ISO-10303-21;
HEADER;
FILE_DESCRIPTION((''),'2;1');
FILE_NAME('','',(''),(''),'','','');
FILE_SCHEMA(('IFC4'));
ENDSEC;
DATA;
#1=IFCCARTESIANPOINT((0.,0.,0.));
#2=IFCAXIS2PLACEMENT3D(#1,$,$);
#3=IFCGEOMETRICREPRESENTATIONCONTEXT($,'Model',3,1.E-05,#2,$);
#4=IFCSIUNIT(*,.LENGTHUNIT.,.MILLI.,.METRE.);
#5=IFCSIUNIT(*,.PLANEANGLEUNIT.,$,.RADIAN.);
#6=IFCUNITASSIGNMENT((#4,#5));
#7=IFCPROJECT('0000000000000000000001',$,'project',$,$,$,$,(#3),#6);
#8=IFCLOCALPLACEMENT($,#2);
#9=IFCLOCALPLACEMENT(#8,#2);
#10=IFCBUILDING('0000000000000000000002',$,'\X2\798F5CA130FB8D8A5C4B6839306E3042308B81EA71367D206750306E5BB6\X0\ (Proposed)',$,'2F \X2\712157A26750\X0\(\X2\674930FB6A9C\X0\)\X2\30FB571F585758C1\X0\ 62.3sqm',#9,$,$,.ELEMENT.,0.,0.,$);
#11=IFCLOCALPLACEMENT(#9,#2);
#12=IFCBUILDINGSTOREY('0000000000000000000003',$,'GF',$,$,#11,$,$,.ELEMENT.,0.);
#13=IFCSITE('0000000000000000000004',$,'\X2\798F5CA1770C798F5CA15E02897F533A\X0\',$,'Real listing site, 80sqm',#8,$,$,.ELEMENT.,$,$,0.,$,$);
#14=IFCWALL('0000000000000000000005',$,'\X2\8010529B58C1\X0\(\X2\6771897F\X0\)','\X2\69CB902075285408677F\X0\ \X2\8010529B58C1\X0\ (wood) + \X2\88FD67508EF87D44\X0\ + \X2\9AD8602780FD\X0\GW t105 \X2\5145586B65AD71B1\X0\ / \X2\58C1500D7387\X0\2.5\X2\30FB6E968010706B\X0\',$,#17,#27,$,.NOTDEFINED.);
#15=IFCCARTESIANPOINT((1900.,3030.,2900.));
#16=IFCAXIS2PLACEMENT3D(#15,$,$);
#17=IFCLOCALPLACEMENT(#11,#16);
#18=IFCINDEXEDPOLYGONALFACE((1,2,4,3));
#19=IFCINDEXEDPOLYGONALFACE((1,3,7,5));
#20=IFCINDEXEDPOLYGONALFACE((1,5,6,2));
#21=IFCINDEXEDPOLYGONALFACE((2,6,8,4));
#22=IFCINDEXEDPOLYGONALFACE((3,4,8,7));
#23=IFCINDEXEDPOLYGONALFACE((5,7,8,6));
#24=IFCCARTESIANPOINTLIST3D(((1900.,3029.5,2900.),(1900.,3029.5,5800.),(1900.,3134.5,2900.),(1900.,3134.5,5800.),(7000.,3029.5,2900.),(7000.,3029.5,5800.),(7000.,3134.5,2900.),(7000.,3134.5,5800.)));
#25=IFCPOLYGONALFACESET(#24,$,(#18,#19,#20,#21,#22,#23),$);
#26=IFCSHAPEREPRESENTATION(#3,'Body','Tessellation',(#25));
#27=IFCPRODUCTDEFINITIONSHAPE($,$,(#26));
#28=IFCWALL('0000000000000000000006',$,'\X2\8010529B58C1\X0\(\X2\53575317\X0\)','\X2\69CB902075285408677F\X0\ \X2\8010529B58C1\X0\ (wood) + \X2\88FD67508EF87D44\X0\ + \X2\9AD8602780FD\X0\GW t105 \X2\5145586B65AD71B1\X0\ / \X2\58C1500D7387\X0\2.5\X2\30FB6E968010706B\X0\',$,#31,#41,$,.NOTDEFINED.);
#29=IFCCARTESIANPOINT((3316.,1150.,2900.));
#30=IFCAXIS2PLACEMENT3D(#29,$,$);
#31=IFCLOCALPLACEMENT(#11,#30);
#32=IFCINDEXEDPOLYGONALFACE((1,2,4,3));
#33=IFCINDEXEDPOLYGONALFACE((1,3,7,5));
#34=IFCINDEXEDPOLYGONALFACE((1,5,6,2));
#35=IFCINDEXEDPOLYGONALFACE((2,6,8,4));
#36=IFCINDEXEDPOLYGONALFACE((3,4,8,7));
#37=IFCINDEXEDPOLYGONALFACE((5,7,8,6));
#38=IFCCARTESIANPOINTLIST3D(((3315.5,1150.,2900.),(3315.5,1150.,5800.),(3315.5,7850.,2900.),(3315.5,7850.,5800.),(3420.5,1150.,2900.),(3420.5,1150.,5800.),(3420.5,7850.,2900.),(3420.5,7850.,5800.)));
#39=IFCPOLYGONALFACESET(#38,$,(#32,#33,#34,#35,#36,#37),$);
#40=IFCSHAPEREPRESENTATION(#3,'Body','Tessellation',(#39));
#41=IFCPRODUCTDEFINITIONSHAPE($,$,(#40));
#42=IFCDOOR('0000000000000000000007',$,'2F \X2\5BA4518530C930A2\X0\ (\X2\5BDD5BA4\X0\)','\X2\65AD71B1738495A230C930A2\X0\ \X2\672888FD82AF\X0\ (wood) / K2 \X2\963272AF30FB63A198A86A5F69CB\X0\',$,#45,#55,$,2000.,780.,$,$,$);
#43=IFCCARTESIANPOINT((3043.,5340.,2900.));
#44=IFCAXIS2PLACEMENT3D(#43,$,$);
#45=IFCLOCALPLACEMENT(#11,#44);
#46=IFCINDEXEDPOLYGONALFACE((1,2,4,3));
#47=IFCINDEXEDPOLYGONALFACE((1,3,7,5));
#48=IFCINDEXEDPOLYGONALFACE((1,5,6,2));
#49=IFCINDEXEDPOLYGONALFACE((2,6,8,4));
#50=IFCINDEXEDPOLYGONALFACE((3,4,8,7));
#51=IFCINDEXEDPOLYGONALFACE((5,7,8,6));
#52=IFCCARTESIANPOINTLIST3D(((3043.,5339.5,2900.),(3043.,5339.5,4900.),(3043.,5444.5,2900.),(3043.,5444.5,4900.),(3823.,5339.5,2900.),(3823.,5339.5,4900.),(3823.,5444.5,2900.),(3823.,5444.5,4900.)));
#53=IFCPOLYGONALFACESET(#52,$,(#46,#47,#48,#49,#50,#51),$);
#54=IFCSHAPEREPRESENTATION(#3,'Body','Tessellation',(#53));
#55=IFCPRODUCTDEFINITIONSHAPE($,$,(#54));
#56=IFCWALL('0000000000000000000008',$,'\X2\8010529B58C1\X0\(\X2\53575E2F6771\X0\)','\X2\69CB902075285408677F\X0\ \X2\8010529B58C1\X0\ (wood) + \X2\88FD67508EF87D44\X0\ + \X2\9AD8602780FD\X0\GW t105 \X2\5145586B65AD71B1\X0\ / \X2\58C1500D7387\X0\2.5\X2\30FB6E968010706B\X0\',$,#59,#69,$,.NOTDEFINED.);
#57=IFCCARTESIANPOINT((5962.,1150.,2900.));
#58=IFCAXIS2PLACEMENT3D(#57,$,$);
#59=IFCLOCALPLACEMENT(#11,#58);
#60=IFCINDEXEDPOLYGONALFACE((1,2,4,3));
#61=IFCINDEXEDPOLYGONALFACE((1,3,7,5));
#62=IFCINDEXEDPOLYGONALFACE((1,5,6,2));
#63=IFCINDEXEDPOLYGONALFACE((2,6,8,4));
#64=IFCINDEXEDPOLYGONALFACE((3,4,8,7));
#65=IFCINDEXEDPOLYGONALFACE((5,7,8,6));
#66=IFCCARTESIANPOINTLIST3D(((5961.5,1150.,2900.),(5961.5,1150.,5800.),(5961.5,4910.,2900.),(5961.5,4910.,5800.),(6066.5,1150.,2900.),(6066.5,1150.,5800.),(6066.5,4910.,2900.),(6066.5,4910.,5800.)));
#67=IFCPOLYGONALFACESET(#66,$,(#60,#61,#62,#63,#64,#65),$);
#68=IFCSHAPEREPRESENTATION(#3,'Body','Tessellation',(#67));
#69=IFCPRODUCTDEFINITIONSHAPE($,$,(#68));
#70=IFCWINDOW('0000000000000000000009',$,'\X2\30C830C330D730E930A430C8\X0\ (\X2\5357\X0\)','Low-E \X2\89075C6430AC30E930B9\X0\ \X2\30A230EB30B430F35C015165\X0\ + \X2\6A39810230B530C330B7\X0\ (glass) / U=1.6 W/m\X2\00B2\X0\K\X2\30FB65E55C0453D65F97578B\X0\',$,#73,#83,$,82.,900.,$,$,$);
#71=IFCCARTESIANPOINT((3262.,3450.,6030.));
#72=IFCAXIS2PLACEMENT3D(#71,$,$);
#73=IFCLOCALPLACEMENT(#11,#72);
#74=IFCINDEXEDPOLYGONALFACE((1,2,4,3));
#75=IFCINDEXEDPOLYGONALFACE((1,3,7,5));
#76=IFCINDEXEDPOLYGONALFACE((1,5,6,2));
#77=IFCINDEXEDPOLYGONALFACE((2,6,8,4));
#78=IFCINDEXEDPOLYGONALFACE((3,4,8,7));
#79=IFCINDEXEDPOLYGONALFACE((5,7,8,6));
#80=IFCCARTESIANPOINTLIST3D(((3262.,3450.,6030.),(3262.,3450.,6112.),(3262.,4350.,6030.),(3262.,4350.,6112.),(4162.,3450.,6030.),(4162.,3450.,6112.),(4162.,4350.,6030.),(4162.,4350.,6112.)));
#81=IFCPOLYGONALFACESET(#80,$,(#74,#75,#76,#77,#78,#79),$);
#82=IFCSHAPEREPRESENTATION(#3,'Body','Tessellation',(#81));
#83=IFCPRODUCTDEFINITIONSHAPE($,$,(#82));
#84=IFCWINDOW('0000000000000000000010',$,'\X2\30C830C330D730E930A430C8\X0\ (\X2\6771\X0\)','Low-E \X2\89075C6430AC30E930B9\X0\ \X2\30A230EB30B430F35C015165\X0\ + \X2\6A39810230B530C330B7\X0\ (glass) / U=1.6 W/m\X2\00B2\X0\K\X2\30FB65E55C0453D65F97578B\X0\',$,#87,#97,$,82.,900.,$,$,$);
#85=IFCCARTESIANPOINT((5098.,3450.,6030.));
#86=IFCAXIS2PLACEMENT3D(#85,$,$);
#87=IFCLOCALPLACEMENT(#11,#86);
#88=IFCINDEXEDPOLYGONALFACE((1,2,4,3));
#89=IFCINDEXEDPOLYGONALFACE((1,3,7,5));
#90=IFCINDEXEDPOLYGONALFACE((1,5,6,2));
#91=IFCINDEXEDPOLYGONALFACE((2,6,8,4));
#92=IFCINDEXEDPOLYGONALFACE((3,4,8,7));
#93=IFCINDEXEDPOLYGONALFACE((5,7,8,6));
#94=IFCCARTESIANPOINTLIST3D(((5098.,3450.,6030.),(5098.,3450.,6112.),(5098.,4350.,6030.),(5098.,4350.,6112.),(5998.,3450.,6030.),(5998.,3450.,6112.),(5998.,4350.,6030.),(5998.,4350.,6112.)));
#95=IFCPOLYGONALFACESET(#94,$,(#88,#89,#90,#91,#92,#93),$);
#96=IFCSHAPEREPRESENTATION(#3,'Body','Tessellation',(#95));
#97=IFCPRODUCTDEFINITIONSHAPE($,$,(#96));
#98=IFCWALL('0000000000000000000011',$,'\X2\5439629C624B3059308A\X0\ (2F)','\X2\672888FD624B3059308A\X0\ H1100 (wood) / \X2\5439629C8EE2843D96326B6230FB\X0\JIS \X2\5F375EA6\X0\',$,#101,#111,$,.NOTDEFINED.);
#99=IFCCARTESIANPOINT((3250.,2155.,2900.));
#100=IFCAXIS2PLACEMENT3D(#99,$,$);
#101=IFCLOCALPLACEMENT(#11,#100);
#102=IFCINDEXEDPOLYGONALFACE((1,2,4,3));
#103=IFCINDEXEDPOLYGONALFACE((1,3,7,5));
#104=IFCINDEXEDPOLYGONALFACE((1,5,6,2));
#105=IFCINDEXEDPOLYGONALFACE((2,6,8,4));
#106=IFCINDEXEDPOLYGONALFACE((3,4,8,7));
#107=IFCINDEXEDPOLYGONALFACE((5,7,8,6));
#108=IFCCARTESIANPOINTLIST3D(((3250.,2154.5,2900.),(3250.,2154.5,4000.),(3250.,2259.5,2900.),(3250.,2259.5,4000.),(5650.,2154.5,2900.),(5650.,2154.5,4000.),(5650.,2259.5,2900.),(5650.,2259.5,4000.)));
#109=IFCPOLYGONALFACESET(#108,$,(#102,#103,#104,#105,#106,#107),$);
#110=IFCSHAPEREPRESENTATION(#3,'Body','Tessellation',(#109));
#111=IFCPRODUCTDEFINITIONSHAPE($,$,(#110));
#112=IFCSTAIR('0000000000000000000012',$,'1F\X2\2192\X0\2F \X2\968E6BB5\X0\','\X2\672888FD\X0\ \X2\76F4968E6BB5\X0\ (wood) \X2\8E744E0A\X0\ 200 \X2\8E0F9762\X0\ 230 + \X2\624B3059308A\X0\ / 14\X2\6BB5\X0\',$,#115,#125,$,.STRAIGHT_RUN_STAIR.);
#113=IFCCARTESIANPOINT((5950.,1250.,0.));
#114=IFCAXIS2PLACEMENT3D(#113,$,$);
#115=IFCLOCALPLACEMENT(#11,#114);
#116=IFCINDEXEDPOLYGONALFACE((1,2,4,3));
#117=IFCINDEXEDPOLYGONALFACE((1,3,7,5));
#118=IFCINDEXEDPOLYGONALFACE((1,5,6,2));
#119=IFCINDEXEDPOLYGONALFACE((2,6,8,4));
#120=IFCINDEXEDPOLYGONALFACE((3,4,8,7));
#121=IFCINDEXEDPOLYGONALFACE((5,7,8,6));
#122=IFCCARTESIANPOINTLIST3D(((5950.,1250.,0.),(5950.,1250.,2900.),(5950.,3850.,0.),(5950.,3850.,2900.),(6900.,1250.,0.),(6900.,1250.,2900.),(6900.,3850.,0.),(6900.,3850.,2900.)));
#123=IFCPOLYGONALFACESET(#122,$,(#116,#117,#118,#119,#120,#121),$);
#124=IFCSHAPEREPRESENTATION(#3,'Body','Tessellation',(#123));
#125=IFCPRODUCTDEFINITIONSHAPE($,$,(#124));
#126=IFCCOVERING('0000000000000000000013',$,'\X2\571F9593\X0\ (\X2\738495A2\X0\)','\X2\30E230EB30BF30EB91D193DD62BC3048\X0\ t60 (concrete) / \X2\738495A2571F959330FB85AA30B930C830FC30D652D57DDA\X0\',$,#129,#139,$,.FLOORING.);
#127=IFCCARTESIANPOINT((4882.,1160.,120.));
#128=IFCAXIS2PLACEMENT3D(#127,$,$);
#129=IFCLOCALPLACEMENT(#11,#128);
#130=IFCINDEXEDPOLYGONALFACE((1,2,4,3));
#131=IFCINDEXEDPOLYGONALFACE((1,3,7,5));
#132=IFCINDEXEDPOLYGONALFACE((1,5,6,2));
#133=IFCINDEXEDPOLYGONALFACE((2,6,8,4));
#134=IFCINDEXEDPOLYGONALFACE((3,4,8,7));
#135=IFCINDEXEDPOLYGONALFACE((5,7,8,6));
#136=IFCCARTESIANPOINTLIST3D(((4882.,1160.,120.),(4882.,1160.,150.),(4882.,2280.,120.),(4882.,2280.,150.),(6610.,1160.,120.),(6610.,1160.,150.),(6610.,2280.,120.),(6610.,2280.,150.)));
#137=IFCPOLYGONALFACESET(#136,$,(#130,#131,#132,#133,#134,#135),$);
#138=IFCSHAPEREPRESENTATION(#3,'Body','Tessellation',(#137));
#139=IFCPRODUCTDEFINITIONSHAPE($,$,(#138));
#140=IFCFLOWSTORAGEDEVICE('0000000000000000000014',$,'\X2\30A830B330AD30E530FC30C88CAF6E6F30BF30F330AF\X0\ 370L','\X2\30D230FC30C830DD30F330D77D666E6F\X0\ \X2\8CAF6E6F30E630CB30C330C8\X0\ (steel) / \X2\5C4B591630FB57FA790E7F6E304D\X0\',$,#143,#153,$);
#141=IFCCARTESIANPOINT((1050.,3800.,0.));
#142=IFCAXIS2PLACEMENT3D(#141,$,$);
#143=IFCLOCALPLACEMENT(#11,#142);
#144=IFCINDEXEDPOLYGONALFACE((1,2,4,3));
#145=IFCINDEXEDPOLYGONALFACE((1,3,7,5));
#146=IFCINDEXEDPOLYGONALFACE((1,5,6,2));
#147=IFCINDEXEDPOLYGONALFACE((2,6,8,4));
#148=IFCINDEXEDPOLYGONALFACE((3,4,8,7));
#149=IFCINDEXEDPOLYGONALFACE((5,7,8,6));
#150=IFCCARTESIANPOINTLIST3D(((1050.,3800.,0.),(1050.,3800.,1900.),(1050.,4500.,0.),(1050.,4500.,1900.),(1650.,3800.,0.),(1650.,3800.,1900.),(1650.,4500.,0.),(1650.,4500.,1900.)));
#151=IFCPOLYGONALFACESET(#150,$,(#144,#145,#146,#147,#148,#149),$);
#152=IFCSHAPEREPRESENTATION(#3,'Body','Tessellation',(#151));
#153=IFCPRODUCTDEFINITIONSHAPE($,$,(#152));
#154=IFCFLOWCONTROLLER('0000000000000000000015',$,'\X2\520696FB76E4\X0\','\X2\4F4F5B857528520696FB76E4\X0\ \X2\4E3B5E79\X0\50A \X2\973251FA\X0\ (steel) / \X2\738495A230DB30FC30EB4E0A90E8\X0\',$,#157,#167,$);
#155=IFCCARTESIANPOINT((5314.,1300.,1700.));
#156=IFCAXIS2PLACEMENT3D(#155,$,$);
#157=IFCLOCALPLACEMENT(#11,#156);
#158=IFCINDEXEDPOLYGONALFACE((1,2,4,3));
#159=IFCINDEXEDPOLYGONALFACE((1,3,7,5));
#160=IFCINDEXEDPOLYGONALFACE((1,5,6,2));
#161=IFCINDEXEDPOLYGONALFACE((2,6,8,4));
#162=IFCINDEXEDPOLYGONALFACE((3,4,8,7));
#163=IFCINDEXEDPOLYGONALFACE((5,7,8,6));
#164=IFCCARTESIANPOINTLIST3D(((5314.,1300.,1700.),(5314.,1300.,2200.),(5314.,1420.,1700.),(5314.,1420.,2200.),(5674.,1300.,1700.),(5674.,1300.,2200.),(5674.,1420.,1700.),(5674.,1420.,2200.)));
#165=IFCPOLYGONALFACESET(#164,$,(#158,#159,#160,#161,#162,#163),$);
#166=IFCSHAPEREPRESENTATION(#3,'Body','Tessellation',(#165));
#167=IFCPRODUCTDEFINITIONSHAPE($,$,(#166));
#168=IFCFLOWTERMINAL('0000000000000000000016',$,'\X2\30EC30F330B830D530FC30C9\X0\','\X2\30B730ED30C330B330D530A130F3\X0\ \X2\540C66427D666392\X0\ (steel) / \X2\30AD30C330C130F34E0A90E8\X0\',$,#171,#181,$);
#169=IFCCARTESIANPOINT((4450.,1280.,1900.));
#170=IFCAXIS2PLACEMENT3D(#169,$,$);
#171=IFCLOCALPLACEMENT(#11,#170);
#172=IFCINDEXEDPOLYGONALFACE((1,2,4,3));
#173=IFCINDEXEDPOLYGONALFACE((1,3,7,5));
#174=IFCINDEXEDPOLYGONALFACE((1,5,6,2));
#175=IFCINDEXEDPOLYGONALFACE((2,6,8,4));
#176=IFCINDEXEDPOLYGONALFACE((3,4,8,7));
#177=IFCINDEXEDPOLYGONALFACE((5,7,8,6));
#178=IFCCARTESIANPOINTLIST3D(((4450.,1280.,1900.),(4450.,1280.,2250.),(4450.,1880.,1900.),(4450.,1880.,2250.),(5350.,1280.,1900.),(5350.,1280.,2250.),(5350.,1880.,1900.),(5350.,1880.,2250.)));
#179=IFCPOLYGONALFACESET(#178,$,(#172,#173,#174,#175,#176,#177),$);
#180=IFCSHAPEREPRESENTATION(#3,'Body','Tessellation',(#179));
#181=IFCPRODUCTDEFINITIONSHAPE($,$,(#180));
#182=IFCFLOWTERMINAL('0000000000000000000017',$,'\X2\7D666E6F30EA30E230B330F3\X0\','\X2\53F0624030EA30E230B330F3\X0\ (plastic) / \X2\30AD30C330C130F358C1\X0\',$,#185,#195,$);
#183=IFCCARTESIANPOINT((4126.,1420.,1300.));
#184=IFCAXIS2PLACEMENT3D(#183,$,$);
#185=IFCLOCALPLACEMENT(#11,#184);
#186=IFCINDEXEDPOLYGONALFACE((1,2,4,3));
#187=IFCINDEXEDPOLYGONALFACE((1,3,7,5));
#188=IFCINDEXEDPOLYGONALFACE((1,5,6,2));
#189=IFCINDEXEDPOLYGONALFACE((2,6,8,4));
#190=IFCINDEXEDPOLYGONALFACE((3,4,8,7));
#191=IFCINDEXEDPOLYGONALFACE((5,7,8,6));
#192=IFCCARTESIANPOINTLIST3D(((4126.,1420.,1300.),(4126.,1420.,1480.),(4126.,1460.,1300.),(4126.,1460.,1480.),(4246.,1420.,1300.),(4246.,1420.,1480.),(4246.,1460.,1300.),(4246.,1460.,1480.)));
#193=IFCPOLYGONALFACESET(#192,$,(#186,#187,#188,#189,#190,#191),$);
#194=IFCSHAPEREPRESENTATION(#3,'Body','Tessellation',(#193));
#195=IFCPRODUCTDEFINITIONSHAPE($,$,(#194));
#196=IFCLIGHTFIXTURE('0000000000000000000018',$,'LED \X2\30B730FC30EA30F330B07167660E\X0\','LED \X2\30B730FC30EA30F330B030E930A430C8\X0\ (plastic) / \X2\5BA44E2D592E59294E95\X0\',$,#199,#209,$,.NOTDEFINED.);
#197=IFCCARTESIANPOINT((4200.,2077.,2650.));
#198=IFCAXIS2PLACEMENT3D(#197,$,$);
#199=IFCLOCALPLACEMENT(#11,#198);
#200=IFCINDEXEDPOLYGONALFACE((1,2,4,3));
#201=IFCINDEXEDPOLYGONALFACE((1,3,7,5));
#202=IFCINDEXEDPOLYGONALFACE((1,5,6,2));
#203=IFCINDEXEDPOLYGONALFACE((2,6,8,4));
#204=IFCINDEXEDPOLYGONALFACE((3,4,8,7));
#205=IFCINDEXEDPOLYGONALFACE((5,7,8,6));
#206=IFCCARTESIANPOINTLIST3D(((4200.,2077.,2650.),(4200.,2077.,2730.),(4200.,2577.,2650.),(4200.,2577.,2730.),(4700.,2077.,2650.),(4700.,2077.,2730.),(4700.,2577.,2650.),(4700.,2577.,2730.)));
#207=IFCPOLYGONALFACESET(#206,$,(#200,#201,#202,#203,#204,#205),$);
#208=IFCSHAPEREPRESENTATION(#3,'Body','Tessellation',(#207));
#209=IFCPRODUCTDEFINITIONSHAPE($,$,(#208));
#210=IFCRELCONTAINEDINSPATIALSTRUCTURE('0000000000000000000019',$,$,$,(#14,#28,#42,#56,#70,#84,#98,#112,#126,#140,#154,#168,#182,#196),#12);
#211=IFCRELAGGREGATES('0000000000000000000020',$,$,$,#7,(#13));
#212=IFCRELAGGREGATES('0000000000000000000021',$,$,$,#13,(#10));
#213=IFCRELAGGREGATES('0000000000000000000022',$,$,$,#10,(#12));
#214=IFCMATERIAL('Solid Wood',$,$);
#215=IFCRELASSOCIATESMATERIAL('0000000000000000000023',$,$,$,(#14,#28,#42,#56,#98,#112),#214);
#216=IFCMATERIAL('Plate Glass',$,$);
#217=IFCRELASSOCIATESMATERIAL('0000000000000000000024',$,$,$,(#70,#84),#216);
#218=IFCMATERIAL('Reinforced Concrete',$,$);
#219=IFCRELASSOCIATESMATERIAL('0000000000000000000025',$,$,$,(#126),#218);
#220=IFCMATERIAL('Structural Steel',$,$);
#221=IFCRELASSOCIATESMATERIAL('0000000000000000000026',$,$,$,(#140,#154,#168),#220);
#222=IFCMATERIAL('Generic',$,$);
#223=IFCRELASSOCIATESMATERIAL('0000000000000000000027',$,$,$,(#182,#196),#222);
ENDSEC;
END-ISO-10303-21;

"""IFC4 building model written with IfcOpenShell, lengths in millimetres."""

from ifc_helpers import new_model, si_unit, frame, frame_2d, origin, place, context, project, spatial, rectangle, extrude, material, element, fill, save


model = new_model("IFC4")

# Units and contexts
model_context = context("Model", 3, precision=1e-05, world=origin())
ifc_project = project(units=[si_unit("LENGTHUNIT", "METRE", prefix="MILLI"), si_unit("PLANEANGLEUNIT", "RADIAN")], contexts=[model_context])

# Site, building, storey
site_placement = place(None, origin())
site = spatial("IfcSite", under=ifc_project, at=site_placement, Name="福岡県福岡市西区", ObjectType="Real listing site, 80sqm", CompositionType="ELEMENT", RefElevation=0.0)
building_placement = place(site_placement, origin())
building = spatial("IfcBuilding", under=site, at=building_placement, Name="福岡・越屋根のある自然素材の家 (Proposed)", ObjectType="2F 無垢材(杉・檜)・土塗壁 62.3sqm", CompositionType="ELEMENT", ElevationOfRefHeight=0.0, ElevationOfTerrain=0.0)
storey_placement = place(building_placement, origin())
storey = spatial("IfcBuildingStorey", under=building, at=storey_placement, Name="GF", CompositionType="ELEMENT", Elevation=0.0)

# Shared definitions
ifc_material_1 = material(Name="Solid Wood")

# Wall
wall_1_placement = place(storey_placement, frame((1900.0, 3030.0, 2900.0)))
element("IfcWall", 1, at=wall_1_placement, inside=storey, material=ifc_material_1, Name="耐力壁(東西)", Description="構造用合板 耐力壁 (wood) + 製材軸組 + 高性能GW t105 充填断熱 / 壁倍率2.5・準耐火", PredefinedType="NOTDEFINED", context=model_context, shape_type="SweptSolid", body=[
    extrude(rectangle(XDim=5100.0, YDim=105.0, at=frame_2d((2550.0, 52.0))), frame((1900.0, 3030.0, 2900.0)), (0.0, 0.0, 1.0), 2900.0),
])

# Wall, opening, door
wall_2_placement = place(storey_placement, frame((3316.0, 1150.0, 2900.0)))
wall_2 = element("IfcWall", 2, at=wall_2_placement, inside=storey, material=ifc_material_1, Name="耐力壁(南北)", Description="構造用合板 耐力壁 (wood) + 製材軸組 + 高性能GW t105 充填断熱 / 壁倍率2.5・準耐火", PredefinedType="NOTDEFINED", context=model_context, shape_type="SweptSolid", body=[
    extrude(rectangle(XDim=105.0, YDim=6700.0, at=frame_2d((52.0, 3350.0))), frame((3316.0, 1150.0, 2900.0)), (0.0, 0.0, 1.0), 2900.0),
])
opening_placement = place(storey_placement, frame((3043.0, 5340.0, 2900.0)))
opening = element("IfcOpeningElement", 3, at=opening_placement, cuts=wall_2, PredefinedType="NOTDEFINED", context=model_context, shape_type="SweptSolid", body=[
    extrude(rectangle(XDim=780.0, YDim=105.0, at=frame_2d((390.0, 52.0))), frame((3043.0, 5340.0, 2900.0)), (0.0, 0.0, 1.0), 2000.0),
])
door_placement = place(storey_placement, frame((3043.0, 5340.0, 2900.0)))
door = element("IfcDoor", 4, at=door_placement, inside=storey, material=ifc_material_1, Name="2F 室内ドア (寝室)", Description="断熱玄関ドア 木製芯 (wood) / K2 防犯・採風機構", OverallHeight=2000.0, OverallWidth=780.0, context=model_context, shape_type="SweptSolid", body=[
    extrude(rectangle(XDim=780.0, YDim=105.0, at=frame_2d((390.0, 52.0))), frame((3043.0, 5340.0, 2900.0)), (0.0, 0.0, 1.0), 2000.0),
])
fill(opening, door)

# Wall
wall_3_placement = place(storey_placement, frame((5962.0, 1150.0, 2900.0)))
element("IfcWall", 5, at=wall_3_placement, inside=storey, material=ifc_material_1, Name="耐力壁(南帯東)", Description="構造用合板 耐力壁 (wood) + 製材軸組 + 高性能GW t105 充填断熱 / 壁倍率2.5・準耐火", PredefinedType="NOTDEFINED", context=model_context, shape_type="SweptSolid", body=[
    extrude(rectangle(XDim=105.0, YDim=3760.0, at=frame_2d((52.0, 1880.0))), frame((5962.0, 1150.0, 2900.0)), (0.0, 0.0, 1.0), 2900.0),
])

# Windows
ifc_material_2 = material(Name="Plate Glass")
window_1_placement = place(storey_placement, frame((3262.0, 3450.0, 6030.0)))
element("IfcWindow", 6, at=window_1_placement, inside=storey, material=ifc_material_2, Name="トップライト (南)", Description="Low-E 複層ガラス アルゴン封入 + 樹脂サッシ (glass) / U=1.6 W/m²K・日射取得型", OverallHeight=82.0, OverallWidth=900.0, context=model_context, shape_type="SweptSolid", body=[
    extrude(rectangle(XDim=900.0, YDim=900.0, at=frame_2d((450.0, 450.0))), frame((3262.0, 3450.0, 6030.0)), (0.0, 0.0, 1.0), 82.0),
])
window_2_placement = place(storey_placement, frame((5098.0, 3450.0, 6030.0)))
element("IfcWindow", 7, at=window_2_placement, inside=storey, material=ifc_material_2, Name="トップライト (東)", Description="Low-E 複層ガラス アルゴン封入 + 樹脂サッシ (glass) / U=1.6 W/m²K・日射取得型", OverallHeight=82.0, OverallWidth=900.0, context=model_context, shape_type="SweptSolid", body=[
    extrude(rectangle(XDim=900.0, YDim=900.0, at=frame_2d((450.0, 450.0))), frame((5098.0, 3450.0, 6030.0)), (0.0, 0.0, 1.0), 82.0),
])

# Wall
wall_4_placement = place(storey_placement, frame((3250.0, 2155.0, 2900.0)))
element("IfcWall", 8, at=wall_4_placement, inside=storey, material=ifc_material_1, Name="吹抜手すり (2F)", Description="木製手すり H1100 (wood) / 吹抜転落防止・JIS 強度", PredefinedType="NOTDEFINED", context=model_context, shape_type="SweptSolid", body=[
    extrude(rectangle(XDim=2400.0, YDim=105.0, at=frame_2d((1200.0, 52.0))), frame((3250.0, 2155.0, 2900.0)), (0.0, 0.0, 1.0), 1100.0),
])

# Stair
stair_placement = place(storey_placement, frame((5950.0, 1250.0, 0.0)))
element("IfcStair", 9, at=stair_placement, inside=storey, material=ifc_material_1, Name="1F→2F 階段", Description="木製 直階段 (wood) 蹴上 200 踏面 230 + 手すり / 14段", PredefinedType="STRAIGHT_RUN_STAIR", context=model_context, shape_type="SweptSolid", body=[
    extrude(rectangle(XDim=950.0, YDim=2600.0, at=frame_2d((475.0, 1300.0))), frame((5950.0, 1250.0, 0.0)), (0.0, 0.0, 1.0), 2900.0),
])

# Covering
ifc_material_3 = material(Name="Reinforced Concrete")
covering_placement = place(storey_placement, frame((4882.0, 1160.0, 120.0)))
element("IfcCovering", 10, at=covering_placement, inside=storey, material=ifc_material_3, Name="土間 (玄関)", Description="モルタル金鏝押え t60 (concrete) / 玄関土間・薪ストーブ動線", PredefinedType="FLOORING", context=model_context, shape_type="SweptSolid", body=[
    extrude(rectangle(XDim=1728.0, YDim=1120.0, at=frame_2d((864.0, 560.0))), frame((4882.0, 1160.0, 120.0)), (0.0, 0.0, 1.0), 30.0),
])

# Flow storage device
ifc_material_4 = material(Name="Structural Steel")
flow_storage_device_placement = place(storey_placement, frame((1050.0, 3800.0, 0.0)))
element("IfcFlowStorageDevice", 11, at=flow_storage_device_placement, inside=storey, material=ifc_material_4, Name="エコキュート貯湯タンク 370L", Description="ヒートポンプ給湯 貯湯ユニット (steel) / 屋外・基礎置き", context=model_context, shape_type="SweptSolid", body=[
    extrude(rectangle(XDim=600.0, YDim=700.0, at=frame_2d((300.0, 350.0))), frame((1050.0, 3800.0, 0.0)), (0.0, 0.0, 1.0), 1900.0),
])

# Flow controller
flow_controller_placement = place(storey_placement, frame((5314.0, 1300.0, 1700.0)))
element("IfcFlowController", 12, at=flow_controller_placement, inside=storey, material=ifc_material_4, Name="分電盤", Description="住宅用分電盤 主幹50A 露出 (steel) / 玄関ホール上部", context=model_context, shape_type="SweptSolid", body=[
    extrude(rectangle(XDim=360.0, YDim=120.0, at=frame_2d((180.0, 60.0))), frame((5314.0, 1300.0, 1700.0)), (0.0, 0.0, 1.0), 500.0),
])

# Flow terminals
flow_terminal_1_placement = place(storey_placement, frame((4450.0, 1280.0, 1900.0)))
element("IfcFlowTerminal", 13, at=flow_terminal_1_placement, inside=storey, material=ifc_material_4, Name="レンジフード", Description="シロッコファン 同時給排 (steel) / キッチン上部", context=model_context, shape_type="SweptSolid", body=[
    extrude(rectangle(XDim=900.0, YDim=600.0, at=frame_2d((450.0, 300.0))), frame((4450.0, 1280.0, 1900.0)), (0.0, 0.0, 1.0), 350.0),
])
ifc_material_5 = material(Name="Generic")
flow_terminal_2_placement = place(storey_placement, frame((4126.0, 1420.0, 1300.0)))
element("IfcFlowTerminal", 14, at=flow_terminal_2_placement, inside=storey, material=ifc_material_5, Name="給湯リモコン", Description="台所リモコン (plastic) / キッチン壁", context=model_context, shape_type="SweptSolid", body=[
    extrude(rectangle(XDim=120.0, YDim=40.0, at=frame_2d((60.0, 20.0))), frame((4126.0, 1420.0, 1300.0)), (0.0, 0.0, 1.0), 180.0),
])

# Light fixture
light_fixture_1_placement = place(storey_placement, frame((4200.0, 2077.0, 2650.0)))
element("IfcLightFixture", 15, at=light_fixture_1_placement, inside=storey, material=ifc_material_5, Name="LED シーリング照明", Description="LED シーリングライト (plastic) / 室中央天井", PredefinedType="NOTDEFINED", context=model_context, shape_type="SweptSolid", body=[
    extrude(rectangle(XDim=500.0, YDim=500.0, at=frame_2d((250.0, 250.0))), frame((4200.0, 2077.0, 2650.0)), (0.0, 0.0, 1.0), 80.0),
])

save(model, "model.ifc")
